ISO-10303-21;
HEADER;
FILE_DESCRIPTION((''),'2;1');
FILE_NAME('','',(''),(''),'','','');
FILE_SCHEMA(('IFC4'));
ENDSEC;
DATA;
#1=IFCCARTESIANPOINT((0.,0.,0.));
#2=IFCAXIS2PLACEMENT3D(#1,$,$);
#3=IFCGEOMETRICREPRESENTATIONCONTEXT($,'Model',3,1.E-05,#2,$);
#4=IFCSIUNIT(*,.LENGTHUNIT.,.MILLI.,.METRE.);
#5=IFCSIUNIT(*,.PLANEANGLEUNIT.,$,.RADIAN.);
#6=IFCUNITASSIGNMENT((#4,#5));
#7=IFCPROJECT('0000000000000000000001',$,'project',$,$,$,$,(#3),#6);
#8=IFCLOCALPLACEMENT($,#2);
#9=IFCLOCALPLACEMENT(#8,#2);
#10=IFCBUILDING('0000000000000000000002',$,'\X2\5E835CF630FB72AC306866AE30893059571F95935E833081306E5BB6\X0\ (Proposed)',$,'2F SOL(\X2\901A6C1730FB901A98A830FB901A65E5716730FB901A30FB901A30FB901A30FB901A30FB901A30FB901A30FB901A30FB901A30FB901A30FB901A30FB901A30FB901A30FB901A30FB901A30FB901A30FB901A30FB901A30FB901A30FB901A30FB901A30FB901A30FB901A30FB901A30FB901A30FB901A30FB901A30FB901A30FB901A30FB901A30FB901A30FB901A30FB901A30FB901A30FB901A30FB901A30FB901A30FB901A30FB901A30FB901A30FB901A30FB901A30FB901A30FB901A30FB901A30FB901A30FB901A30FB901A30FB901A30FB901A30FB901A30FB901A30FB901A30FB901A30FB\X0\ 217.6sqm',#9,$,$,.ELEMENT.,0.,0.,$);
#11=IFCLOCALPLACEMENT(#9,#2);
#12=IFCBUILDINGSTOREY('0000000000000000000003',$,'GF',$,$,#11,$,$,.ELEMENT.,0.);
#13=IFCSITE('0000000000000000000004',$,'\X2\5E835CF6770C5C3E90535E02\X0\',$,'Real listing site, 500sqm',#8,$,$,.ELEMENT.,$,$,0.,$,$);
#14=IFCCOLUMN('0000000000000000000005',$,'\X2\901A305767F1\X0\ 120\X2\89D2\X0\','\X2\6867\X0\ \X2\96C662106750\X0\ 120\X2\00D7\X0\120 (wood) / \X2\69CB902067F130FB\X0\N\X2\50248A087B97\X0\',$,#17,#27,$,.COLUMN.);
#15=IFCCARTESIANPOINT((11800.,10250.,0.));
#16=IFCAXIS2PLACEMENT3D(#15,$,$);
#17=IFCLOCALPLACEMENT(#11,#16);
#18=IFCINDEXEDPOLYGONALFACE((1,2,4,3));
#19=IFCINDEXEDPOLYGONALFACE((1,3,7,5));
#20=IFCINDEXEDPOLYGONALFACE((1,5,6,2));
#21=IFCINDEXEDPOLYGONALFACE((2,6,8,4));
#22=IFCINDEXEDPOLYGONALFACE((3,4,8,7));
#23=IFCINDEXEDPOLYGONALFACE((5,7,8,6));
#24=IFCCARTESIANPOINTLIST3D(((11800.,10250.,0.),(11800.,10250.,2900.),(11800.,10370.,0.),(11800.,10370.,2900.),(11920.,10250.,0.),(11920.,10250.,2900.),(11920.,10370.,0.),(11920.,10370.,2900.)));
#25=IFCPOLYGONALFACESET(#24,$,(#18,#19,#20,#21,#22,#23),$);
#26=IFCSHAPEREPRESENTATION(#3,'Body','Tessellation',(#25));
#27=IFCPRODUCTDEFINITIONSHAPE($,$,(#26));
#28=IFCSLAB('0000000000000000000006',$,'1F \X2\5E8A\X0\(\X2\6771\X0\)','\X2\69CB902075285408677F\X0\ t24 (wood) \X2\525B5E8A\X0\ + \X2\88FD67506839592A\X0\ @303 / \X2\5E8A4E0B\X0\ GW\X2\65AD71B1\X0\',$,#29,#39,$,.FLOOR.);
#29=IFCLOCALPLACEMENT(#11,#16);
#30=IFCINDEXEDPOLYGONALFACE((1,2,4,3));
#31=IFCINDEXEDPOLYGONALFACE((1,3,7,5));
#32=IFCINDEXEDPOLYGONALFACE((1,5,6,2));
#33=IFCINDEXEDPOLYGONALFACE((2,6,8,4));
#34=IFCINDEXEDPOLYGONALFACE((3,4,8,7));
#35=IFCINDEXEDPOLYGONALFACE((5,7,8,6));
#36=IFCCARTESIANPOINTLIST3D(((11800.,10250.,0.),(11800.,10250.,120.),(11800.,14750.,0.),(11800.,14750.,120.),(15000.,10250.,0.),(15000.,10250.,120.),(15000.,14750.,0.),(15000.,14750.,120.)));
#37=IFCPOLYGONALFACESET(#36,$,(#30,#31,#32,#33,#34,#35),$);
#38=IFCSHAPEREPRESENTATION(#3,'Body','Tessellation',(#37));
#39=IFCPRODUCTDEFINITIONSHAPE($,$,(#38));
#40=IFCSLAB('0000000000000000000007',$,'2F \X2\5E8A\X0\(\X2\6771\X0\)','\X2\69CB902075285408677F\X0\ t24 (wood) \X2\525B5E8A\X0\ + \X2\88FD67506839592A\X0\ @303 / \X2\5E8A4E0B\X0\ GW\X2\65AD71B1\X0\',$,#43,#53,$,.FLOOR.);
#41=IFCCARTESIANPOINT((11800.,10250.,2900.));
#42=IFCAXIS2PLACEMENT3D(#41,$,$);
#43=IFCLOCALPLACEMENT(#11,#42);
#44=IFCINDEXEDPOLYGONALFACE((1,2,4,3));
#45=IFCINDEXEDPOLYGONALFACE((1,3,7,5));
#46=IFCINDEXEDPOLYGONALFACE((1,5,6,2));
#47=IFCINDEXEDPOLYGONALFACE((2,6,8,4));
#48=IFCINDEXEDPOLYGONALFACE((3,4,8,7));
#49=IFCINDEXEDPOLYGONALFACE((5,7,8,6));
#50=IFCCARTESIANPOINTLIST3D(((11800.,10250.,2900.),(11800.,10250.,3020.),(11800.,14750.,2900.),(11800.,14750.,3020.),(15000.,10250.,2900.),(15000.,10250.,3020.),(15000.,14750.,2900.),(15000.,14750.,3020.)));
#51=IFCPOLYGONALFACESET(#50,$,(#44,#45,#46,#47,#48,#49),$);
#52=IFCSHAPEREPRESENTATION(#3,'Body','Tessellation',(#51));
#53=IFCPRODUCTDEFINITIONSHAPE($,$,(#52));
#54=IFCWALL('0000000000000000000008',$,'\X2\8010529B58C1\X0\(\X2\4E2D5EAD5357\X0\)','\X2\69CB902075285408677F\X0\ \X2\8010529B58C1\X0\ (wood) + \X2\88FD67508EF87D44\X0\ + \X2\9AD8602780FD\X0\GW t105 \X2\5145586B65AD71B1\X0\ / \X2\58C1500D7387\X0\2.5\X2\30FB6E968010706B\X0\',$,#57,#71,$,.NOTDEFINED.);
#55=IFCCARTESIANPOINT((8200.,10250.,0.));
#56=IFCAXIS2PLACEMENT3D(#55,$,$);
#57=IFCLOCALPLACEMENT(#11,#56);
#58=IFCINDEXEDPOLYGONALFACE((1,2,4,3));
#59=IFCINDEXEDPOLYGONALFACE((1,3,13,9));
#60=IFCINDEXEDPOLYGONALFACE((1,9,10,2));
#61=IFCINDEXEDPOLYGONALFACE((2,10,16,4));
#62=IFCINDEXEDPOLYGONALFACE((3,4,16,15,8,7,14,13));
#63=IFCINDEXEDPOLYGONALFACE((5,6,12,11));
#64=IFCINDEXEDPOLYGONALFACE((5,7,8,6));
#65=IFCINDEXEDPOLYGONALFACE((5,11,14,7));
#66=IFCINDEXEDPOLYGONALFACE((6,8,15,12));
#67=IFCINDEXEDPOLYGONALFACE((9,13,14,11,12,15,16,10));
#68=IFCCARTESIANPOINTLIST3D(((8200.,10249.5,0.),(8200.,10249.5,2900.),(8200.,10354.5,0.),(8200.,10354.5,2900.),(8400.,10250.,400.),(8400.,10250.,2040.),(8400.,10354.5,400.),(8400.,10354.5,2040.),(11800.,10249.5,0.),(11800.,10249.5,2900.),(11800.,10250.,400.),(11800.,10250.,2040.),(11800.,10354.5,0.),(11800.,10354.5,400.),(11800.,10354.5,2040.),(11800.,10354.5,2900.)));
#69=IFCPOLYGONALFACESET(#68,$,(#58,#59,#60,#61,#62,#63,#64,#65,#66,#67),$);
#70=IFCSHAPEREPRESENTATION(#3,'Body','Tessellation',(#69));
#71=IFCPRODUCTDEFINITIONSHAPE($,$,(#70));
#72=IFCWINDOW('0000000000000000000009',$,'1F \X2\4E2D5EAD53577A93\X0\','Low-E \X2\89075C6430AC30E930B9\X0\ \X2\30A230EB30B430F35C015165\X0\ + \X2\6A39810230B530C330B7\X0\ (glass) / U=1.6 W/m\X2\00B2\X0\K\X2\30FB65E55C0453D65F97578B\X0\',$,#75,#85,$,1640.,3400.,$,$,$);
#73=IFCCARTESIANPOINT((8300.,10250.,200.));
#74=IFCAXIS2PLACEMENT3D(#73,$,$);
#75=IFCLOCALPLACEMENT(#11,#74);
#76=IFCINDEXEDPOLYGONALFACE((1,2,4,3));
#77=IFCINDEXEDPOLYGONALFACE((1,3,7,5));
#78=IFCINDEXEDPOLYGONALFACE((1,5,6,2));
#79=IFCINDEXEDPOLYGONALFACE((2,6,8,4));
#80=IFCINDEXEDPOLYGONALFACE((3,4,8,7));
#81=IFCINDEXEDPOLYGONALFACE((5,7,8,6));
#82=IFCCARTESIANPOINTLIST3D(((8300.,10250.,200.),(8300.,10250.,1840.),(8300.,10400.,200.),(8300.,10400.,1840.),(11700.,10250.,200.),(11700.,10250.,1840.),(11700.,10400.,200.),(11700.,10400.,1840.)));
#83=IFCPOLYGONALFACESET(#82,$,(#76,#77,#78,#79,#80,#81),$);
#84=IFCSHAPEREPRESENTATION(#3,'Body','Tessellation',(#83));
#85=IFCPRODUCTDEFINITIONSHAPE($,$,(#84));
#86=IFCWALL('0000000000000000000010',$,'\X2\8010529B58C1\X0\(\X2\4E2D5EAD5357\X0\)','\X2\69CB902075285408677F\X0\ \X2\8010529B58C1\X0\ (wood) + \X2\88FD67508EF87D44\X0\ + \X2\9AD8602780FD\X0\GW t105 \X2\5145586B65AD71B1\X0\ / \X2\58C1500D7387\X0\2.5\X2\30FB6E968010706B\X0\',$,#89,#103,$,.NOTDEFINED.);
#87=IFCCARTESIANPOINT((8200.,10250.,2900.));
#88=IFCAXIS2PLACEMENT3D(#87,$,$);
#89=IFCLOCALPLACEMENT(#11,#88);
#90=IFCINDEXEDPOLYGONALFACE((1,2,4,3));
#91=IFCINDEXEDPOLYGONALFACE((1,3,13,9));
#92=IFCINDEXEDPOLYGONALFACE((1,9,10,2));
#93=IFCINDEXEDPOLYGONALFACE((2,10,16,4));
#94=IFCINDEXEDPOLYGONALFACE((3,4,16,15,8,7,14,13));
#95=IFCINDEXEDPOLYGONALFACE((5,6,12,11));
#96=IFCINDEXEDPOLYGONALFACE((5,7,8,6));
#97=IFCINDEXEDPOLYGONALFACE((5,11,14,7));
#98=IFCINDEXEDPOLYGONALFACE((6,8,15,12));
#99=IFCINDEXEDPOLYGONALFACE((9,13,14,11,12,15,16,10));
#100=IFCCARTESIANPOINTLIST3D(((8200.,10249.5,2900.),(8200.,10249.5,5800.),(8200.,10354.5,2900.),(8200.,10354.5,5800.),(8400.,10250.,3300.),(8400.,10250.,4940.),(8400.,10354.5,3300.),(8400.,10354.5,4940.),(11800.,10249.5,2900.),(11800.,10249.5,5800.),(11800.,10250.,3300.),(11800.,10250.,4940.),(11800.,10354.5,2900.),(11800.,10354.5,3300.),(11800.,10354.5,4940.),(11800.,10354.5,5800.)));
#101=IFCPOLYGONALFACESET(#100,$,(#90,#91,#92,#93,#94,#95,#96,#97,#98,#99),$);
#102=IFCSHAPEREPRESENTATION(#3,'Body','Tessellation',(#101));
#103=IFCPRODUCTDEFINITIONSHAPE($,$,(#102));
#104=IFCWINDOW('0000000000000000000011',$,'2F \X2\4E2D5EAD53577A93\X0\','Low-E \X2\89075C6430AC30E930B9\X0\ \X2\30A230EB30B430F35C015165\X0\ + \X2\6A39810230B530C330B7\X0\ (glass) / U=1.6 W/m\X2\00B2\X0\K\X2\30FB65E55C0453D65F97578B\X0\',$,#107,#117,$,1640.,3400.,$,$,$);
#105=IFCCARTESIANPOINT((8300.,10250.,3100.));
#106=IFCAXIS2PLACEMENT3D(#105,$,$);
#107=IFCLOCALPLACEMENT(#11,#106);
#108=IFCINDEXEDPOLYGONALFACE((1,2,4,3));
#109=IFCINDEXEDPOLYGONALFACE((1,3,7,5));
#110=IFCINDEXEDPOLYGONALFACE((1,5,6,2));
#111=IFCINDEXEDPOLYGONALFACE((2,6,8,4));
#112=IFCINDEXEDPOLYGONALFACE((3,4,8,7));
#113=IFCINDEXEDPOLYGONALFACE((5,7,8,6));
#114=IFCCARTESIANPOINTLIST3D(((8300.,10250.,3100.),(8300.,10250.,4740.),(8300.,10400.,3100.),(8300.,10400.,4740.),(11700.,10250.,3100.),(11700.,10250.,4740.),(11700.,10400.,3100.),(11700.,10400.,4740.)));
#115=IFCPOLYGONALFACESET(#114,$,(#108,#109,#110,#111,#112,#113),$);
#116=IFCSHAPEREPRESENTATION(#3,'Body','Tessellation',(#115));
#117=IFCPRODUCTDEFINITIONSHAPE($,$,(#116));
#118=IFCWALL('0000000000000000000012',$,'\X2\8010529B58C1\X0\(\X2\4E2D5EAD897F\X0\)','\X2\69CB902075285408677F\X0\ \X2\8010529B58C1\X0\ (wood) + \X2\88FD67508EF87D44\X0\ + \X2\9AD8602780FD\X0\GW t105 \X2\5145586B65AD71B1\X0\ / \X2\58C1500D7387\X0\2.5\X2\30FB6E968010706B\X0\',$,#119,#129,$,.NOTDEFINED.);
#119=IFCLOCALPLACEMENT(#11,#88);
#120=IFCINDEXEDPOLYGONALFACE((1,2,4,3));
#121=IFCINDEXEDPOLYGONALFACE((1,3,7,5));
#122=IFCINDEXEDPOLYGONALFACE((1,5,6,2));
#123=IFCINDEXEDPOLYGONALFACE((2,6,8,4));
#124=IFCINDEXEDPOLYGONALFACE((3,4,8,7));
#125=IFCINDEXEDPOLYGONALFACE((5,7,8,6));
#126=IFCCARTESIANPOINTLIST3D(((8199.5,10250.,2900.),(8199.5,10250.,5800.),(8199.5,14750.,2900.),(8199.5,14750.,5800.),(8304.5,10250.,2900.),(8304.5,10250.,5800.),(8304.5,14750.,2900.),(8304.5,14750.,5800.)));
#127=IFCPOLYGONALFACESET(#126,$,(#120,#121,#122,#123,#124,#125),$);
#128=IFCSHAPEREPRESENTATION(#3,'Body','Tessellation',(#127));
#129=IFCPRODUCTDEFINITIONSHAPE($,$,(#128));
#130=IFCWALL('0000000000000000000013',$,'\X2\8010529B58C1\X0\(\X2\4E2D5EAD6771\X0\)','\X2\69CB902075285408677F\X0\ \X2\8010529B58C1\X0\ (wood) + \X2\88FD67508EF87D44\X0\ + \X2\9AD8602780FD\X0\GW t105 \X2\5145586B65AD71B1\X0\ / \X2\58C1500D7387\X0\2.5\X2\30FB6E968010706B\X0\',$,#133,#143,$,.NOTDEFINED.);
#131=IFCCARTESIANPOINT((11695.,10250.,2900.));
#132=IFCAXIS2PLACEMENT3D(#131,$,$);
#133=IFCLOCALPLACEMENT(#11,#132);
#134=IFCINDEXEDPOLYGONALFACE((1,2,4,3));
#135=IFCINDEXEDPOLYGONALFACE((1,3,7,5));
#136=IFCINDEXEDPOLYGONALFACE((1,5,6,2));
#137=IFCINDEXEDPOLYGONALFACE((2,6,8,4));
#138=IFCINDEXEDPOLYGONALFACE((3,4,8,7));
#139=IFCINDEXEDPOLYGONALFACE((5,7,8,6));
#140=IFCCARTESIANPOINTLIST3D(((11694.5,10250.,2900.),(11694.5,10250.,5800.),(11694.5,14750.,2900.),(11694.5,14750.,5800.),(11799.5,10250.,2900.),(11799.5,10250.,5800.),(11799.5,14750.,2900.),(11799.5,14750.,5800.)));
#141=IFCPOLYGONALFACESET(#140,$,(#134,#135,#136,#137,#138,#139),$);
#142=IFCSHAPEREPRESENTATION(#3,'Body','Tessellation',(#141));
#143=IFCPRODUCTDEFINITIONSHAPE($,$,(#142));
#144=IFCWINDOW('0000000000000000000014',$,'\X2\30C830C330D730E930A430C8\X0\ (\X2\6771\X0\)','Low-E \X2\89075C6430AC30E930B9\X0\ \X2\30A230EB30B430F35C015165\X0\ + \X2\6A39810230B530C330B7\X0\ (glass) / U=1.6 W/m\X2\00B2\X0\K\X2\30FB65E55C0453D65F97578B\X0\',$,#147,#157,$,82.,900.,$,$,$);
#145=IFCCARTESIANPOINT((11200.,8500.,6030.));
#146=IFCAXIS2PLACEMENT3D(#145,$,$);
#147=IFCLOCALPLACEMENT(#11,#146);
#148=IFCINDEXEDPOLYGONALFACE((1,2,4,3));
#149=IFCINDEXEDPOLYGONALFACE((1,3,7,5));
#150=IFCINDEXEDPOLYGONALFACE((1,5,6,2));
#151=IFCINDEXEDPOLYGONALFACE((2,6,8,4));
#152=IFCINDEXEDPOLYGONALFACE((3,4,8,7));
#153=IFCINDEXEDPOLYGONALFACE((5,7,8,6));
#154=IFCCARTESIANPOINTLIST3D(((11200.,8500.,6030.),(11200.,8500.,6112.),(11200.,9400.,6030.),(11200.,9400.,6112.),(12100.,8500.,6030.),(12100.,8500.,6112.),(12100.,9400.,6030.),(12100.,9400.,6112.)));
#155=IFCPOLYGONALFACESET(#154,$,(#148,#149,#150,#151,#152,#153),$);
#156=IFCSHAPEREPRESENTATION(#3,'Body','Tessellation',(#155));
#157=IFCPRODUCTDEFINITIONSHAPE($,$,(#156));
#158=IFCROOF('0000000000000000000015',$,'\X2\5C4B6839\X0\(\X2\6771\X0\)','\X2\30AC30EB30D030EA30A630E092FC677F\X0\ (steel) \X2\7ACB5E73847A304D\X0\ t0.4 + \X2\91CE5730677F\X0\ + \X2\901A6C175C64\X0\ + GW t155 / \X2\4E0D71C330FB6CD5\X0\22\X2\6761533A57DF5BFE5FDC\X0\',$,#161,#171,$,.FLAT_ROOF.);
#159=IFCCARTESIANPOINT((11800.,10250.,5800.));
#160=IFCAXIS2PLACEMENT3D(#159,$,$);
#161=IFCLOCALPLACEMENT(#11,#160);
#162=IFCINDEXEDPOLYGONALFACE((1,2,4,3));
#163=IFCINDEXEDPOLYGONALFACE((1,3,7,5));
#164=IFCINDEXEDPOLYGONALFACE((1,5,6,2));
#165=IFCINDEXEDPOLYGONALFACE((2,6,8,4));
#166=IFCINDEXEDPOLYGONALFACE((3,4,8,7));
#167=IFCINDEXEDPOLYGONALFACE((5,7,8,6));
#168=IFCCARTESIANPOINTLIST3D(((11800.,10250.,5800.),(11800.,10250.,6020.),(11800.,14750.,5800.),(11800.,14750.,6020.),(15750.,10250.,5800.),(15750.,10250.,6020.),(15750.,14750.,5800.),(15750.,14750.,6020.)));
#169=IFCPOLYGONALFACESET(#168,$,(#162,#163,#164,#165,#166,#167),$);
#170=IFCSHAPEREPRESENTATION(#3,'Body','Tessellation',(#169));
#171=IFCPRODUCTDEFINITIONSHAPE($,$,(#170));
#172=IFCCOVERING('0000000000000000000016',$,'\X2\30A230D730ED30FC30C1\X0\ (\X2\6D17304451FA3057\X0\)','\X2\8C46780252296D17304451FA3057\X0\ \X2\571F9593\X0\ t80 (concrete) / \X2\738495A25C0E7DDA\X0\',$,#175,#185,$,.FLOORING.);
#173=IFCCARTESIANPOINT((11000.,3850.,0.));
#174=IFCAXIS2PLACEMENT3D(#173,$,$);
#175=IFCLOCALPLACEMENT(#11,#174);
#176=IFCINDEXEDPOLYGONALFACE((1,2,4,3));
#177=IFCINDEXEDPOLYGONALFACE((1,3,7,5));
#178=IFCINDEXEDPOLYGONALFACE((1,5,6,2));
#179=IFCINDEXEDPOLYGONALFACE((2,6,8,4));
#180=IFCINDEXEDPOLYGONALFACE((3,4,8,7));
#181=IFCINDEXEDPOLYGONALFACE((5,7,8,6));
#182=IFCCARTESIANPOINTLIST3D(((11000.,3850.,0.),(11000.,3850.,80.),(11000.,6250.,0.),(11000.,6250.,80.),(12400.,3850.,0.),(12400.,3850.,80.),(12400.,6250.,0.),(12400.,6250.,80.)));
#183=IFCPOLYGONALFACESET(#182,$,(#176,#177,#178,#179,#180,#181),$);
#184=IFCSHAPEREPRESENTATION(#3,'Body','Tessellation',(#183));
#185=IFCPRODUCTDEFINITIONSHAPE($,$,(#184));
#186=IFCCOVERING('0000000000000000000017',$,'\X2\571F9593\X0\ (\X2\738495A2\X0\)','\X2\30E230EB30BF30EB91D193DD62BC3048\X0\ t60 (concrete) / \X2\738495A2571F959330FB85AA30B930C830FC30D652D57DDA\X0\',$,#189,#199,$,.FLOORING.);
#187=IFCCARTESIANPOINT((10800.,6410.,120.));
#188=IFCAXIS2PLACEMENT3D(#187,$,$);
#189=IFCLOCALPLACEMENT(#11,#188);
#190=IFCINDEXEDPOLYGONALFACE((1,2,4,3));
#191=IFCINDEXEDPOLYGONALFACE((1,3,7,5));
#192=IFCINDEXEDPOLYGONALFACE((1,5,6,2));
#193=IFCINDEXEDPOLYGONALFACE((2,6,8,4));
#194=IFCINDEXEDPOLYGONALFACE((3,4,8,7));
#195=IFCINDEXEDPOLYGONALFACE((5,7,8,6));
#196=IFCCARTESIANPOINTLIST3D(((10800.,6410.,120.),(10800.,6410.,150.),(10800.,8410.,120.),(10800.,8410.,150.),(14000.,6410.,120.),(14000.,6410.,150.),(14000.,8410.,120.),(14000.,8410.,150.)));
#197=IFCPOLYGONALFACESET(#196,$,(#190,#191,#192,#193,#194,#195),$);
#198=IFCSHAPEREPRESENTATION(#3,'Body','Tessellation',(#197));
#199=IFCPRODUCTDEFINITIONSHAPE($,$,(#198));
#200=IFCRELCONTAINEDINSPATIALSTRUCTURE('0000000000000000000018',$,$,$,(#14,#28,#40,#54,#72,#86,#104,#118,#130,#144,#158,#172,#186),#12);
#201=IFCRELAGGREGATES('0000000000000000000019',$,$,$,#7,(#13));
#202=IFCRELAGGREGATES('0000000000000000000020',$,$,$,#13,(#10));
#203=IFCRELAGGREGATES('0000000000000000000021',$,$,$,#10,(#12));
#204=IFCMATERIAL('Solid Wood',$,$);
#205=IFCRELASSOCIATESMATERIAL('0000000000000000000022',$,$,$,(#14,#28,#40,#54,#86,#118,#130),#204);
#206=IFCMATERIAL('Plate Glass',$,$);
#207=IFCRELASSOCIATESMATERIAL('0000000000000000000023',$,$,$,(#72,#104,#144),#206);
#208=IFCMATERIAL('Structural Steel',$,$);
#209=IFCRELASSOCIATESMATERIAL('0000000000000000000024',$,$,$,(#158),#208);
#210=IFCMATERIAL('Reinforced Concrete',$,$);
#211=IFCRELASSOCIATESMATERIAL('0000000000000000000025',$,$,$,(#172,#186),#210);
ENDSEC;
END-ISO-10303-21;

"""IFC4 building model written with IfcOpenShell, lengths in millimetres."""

from ifc_helpers import new_model, si_unit, frame, frame_2d, origin, place, context, project, spatial, rectangle, extrude, material, element, fill, save


model = new_model("IFC4")

# Units and contexts
model_context = context("Model", 3, precision=1e-05, world=origin())
ifc_project = project(units=[si_unit("LENGTHUNIT", "METRE", prefix="MILLI"), si_unit("PLANEANGLEUNIT", "RADIAN")], contexts=[model_context])

# Site, building, storey
site_placement = place(None, origin())
site = spatial("IfcSite", under=ifc_project, at=site_placement, Name="広島県尾道市", ObjectType="Real listing site, 500sqm", CompositionType="ELEMENT", RefElevation=0.0)
building_placement = place(site_placement, origin())
building = spatial("IfcBuilding", under=site, at=building_placement, Name="広島・犬と暮らす土間広めの家 (Proposed)", ObjectType="2F SOL(通気・通風・通日照・通・通・通・通・通・通・通・通・通・通・通・通・通・通・通・通・通・通・通・通・通・通・通・通・通・通・通・通・通・通・通・通・通・通・通・通・通・通・通・通・通・通・通・通・通・通・通・通・通・通・通・通・通・ 217.6sqm", CompositionType="ELEMENT", ElevationOfRefHeight=0.0, ElevationOfTerrain=0.0)
storey_placement = place(building_placement, origin())
storey = spatial("IfcBuildingStorey", under=building, at=storey_placement, Name="GF", CompositionType="ELEMENT", Elevation=0.0)

# Column
ifc_material_1 = material(Name="Solid Wood")
column_1_placement = place(storey_placement, frame((11800.0, 10250.0, 0.0)))
element("IfcColumn", 1, at=column_1_placement, inside=storey, material=ifc_material_1, Name="通し柱 120角", Description="桧 集成材 120×120 (wood) / 構造柱・N値計算", PredefinedType="COLUMN", context=model_context, shape_type="SweptSolid", body=[
    extrude(rectangle(XDim=120.0, YDim=120.0, at=frame_2d((60.0, 60.0))), frame((11800.0, 10250.0, 0.0)), (0.0, 0.0, 1.0), 2900.0),
])

# Slabs
slab_1_placement = place(storey_placement, frame((11800.0, 10250.0, 0.0)))
element("IfcSlab", 2, at=slab_1_placement, inside=storey, material=ifc_material_1, Name="1F 床(東)", Description="構造用合板 t24 (wood) 剛床 + 製材根太 @303 / 床下 GW断熱", PredefinedType="FLOOR", context=model_context, shape_type="SweptSolid", body=[
    extrude(rectangle(XDim=3200.0, YDim=4500.0, at=frame_2d((1600.0, 2250.0))), frame((11800.0, 10250.0, 0.0)), (0.0, 0.0, 1.0), 120.0),
])
slab_2_placement = place(storey_placement, frame((11800.0, 10250.0, 2900.0)))
element("IfcSlab", 3, at=slab_2_placement, inside=storey, material=ifc_material_1, Name="2F 床(東)", Description="構造用合板 t24 (wood) 剛床 + 製材根太 @303 / 床下 GW断熱", PredefinedType="FLOOR", context=model_context, shape_type="SweptSolid", body=[
    extrude(rectangle(XDim=3200.0, YDim=4500.0, at=frame_2d((1600.0, 2250.0))), frame((11800.0, 10250.0, 2900.0)), (0.0, 0.0, 1.0), 120.0),
])

# Wall, opening, window
wall_1_placement = place(storey_placement, frame((8200.0, 10250.0, 0.0)))
wall_1 = element("IfcWall", 4, at=wall_1_placement, inside=storey, material=ifc_material_1, Name="耐力壁(中庭南)", Description="構造用合板 耐力壁 (wood) + 製材軸組 + 高性能GW t105 充填断熱 / 壁倍率2.5・準耐火", PredefinedType="NOTDEFINED", context=model_context, shape_type="SweptSolid", body=[
    extrude(rectangle(XDim=3600.0, YDim=105.0, at=frame_2d((1800.0, 52.0))), frame((8200.0, 10250.0, 0.0)), (0.0, 0.0, 1.0), 2900.0),
])
opening_1_placement = place(storey_placement, frame((8300.0, 10250.0, 200.0)))
opening_1 = element("IfcOpeningElement", 5, at=opening_1_placement, cuts=wall_1, PredefinedType="NOTDEFINED", context=model_context, shape_type="SweptSolid", body=[
    extrude(rectangle(XDim=3400.0, YDim=150.0, at=frame_2d((1700.0, 75.0))), frame((8300.0, 10250.0, 200.0)), (0.0, 0.0, 1.0), 1640.0),
])
ifc_material_2 = material(Name="Plate Glass")
window_1_placement = place(storey_placement, frame((8300.0, 10250.0, 200.0)))
window_1 = element("IfcWindow", 6, at=window_1_placement, inside=storey, material=ifc_material_2, Name="1F 中庭南窓", Description="Low-E 複層ガラス アルゴン封入 + 樹脂サッシ (glass) / U=1.6 W/m²K・日射取得型", OverallHeight=1640.0, OverallWidth=3400.0, context=model_context, shape_type="SweptSolid", body=[
    extrude(rectangle(XDim=3400.0, YDim=150.0, at=frame_2d((1700.0, 75.0))), frame((8300.0, 10250.0, 200.0)), (0.0, 0.0, 1.0), 1640.0),
])
fill(opening_1, window_1)

# Wall, opening, window
wall_2_placement = place(storey_placement, frame((8200.0, 10250.0, 2900.0)))
wall_2 = element("IfcWall", 7, at=wall_2_placement, inside=storey, material=ifc_material_1, Name="耐力壁(中庭南)", Description="構造用合板 耐力壁 (wood) + 製材軸組 + 高性能GW t105 充填断熱 / 壁倍率2.5・準耐火", PredefinedType="NOTDEFINED", context=model_context, shape_type="SweptSolid", body=[
    extrude(rectangle(XDim=3600.0, YDim=105.0, at=frame_2d((1800.0, 52.0))), frame((8200.0, 10250.0, 2900.0)), (0.0, 0.0, 1.0), 2900.0),
])
opening_2_placement = place(storey_placement, frame((8300.0, 10250.0, 3100.0)))
opening_2 = element("IfcOpeningElement", 8, at=opening_2_placement, cuts=wall_2, PredefinedType="NOTDEFINED", context=model_context, shape_type="SweptSolid", body=[
    extrude(rectangle(XDim=3400.0, YDim=150.0, at=frame_2d((1700.0, 75.0))), frame((8300.0, 10250.0, 3100.0)), (0.0, 0.0, 1.0), 1640.0),
])
window_2_placement = place(storey_placement, frame((8300.0, 10250.0, 3100.0)))
window_2 = element("IfcWindow", 9, at=window_2_placement, inside=storey, material=ifc_material_2, Name="2F 中庭南窓", Description="Low-E 複層ガラス アルゴン封入 + 樹脂サッシ (glass) / U=1.6 W/m²K・日射取得型", OverallHeight=1640.0, OverallWidth=3400.0, context=model_context, shape_type="SweptSolid", body=[
    extrude(rectangle(XDim=3400.0, YDim=150.0, at=frame_2d((1700.0, 75.0))), frame((8300.0, 10250.0, 3100.0)), (0.0, 0.0, 1.0), 1640.0),
])
fill(opening_2, window_2)

# Walls
wall_3_placement = place(storey_placement, frame((8200.0, 10250.0, 2900.0)))
element("IfcWall", 10, at=wall_3_placement, inside=storey, material=ifc_material_1, Name="耐力壁(中庭西)", Description="構造用合板 耐力壁 (wood) + 製材軸組 + 高性能GW t105 充填断熱 / 壁倍率2.5・準耐火", PredefinedType="NOTDEFINED", context=model_context, shape_type="SweptSolid", body=[
    extrude(rectangle(XDim=105.0, YDim=4500.0, at=frame_2d((52.0, 2250.0))), frame((8200.0, 10250.0, 2900.0)), (0.0, 0.0, 1.0), 2900.0),
])
wall_4_placement = place(storey_placement, frame((11695.0, 10250.0, 2900.0)))
element("IfcWall", 11, at=wall_4_placement, inside=storey, material=ifc_material_1, Name="耐力壁(中庭東)", Description="構造用合板 耐力壁 (wood) + 製材軸組 + 高性能GW t105 充填断熱 / 壁倍率2.5・準耐火", PredefinedType="NOTDEFINED", context=model_context, shape_type="SweptSolid", body=[
    extrude(rectangle(XDim=105.0, YDim=4500.0, at=frame_2d((52.0, 2250.0))), frame((11695.0, 10250.0, 2900.0)), (0.0, 0.0, 1.0), 2900.0),
])

# Window
window_3_placement = place(storey_placement, frame((11200.0, 8500.0, 6030.0)))
element("IfcWindow", 12, at=window_3_placement, inside=storey, material=ifc_material_2, Name="トップライト (東)", Description="Low-E 複層ガラス アルゴン封入 + 樹脂サッシ (glass) / U=1.6 W/m²K・日射取得型", OverallHeight=82.0, OverallWidth=900.0, context=model_context, shape_type="SweptSolid", body=[
    extrude(rectangle(XDim=900.0, YDim=900.0, at=frame_2d((450.0, 450.0))), frame((11200.0, 8500.0, 6030.0)), (0.0, 0.0, 1.0), 82.0),
])

# Roof
ifc_material_3 = material(Name="Structural Steel")
for number, where, name in (
    (13, (11800.0, 10250.0, 5800.0), "屋根(東)"),
):
    element("IfcRoof", number, at=place(storey_placement, frame(where)), inside=storey, material=ifc_material_3, Name=name, Description="ガルバリウム鋼板 (steel) 立平葺き t0.4 + 野地板 + 通気層 + GW t155 / 不燃・法22条区域対応", PredefinedType="FLAT_ROOF", context=model_context, shape_type="SweptSolid", body=[
        extrude(rectangle(XDim=3950.0, YDim=4500.0, at=frame_2d((1975.0, 2250.0))), frame((11800.0, 10250.0, 5800.0)), (0.0, 0.0, 1.0), 220.0),
    ])

# Coverings
ifc_material_4 = material(Name="Reinforced Concrete")
covering_1_placement = place(storey_placement, frame((11000.0, 3850.0, 0.0)))
element("IfcCovering", 14, at=covering_1_placement, inside=storey, material=ifc_material_4, Name="アプローチ (洗い出し)", Description="豆砂利洗い出し 土間 t80 (concrete) / 玄関導線", PredefinedType="FLOORING", context=model_context, shape_type="SweptSolid", body=[
    extrude(rectangle(XDim=1400.0, YDim=2400.0, at=frame_2d((700.0, 1200.0))), frame((11000.0, 3850.0, 0.0)), (0.0, 0.0, 1.0), 80.0),
])
covering_2_placement = place(storey_placement, frame((10800.0, 6410.0, 120.0)))
element("IfcCovering", 15, at=covering_2_placement, inside=storey, material=ifc_material_4, Name="土間 (玄関)", Description="モルタル金鏝押え t60 (concrete) / 玄関土間・薪ストーブ動線", PredefinedType="FLOORING", context=model_context, shape_type="SweptSolid", body=[
    extrude(rectangle(XDim=3200.0, YDim=2000.0, at=frame_2d((1600.0, 1000.0))), frame((10800.0, 6410.0, 120.0)), (0.0, 0.0, 1.0), 30.0),
])

save(model, "model.ifc")
